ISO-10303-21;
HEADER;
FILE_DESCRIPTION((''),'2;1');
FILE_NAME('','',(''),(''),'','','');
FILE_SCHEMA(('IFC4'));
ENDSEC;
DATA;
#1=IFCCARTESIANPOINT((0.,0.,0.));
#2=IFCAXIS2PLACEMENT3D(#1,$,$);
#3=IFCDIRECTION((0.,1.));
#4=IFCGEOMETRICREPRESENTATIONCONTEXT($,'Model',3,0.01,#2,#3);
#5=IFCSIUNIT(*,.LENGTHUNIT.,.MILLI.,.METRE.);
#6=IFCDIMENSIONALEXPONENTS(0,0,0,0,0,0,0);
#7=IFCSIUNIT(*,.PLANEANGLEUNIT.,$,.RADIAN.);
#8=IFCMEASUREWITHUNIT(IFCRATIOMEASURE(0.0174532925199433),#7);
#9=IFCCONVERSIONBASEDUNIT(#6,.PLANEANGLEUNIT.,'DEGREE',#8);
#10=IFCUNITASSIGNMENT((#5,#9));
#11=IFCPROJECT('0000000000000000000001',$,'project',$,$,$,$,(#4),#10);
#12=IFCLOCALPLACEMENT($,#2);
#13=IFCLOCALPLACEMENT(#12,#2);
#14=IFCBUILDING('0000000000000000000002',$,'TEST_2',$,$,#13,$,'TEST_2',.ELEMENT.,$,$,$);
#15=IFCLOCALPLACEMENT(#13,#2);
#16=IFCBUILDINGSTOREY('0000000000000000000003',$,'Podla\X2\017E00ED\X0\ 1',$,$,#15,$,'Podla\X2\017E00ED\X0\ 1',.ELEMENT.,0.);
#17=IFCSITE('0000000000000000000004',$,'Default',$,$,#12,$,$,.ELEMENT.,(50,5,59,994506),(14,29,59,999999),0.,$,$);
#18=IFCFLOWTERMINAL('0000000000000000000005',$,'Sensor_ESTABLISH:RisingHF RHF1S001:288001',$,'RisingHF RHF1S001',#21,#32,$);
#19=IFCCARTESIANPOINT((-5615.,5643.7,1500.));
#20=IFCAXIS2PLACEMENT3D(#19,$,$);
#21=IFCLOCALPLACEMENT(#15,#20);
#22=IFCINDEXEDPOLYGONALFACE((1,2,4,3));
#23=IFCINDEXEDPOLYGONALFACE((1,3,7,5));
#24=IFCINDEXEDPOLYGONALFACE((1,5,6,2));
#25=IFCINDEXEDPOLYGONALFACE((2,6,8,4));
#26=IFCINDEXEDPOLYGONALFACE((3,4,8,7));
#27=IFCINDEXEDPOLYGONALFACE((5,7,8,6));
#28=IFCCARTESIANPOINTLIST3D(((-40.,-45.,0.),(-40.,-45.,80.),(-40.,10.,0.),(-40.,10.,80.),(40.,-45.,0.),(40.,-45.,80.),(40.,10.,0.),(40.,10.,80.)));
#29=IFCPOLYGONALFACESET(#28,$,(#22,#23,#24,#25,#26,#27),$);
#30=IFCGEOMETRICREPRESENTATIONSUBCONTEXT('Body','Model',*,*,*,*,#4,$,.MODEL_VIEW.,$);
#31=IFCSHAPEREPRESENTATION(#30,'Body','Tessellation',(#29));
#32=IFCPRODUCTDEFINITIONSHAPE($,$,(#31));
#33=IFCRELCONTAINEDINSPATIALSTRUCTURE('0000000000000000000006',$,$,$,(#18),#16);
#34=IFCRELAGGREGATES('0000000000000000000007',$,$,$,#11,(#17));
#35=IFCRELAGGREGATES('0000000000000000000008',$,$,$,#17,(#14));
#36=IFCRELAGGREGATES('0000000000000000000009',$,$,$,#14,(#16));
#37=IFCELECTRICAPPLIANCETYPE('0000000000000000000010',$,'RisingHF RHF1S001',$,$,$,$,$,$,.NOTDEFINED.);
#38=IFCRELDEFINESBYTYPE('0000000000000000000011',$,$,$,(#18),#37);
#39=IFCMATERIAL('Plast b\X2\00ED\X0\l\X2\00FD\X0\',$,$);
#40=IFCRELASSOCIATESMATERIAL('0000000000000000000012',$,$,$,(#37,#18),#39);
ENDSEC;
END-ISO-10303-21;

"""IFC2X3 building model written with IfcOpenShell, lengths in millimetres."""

from ifc_helpers import new_model, entity, si_unit, converted_unit, direction, frame, frame_2d, origin, place, context, subcontext, project, spatial, rectangle, extrude, source, transform, mapped, material, type_object, type_shapes, element, save


model = new_model("IFC2X3")

# Units and contexts
model_context = context("Model", 3, precision=0.01, world=origin(), true_north=direction((0.0, 1.0)))
body_context = subcontext(model_context, "Body", "Model", "MODEL_VIEW")
ifc_project = project(units=[si_unit("LENGTHUNIT", "METRE", prefix="MILLI"), converted_unit("PLANEANGLEUNIT", "DEGREE", entity("IfcRatioMeasure", 0.0174532925199433), si_unit("PLANEANGLEUNIT", "RADIAN"), dimensions=[0, 0, 0, 0, 0, 0, 0])], contexts=[model_context])

# Site, building, storey
site_placement = place(None, origin())
site = spatial("IfcSite", under=ifc_project, at=site_placement, Name="Default", CompositionType="ELEMENT", RefLatitude=(50, 5, 59, 994506), RefLongitude=(14, 29, 59, 999999), RefElevation=0.0)
building_placement = place(site_placement, origin())
building = spatial("IfcBuilding", under=site, at=building_placement, Name="TEST_2", LongName="TEST_2", CompositionType="ELEMENT")
storey_placement = place(building_placement, origin())
storey = spatial("IfcBuildingStorey", under=building, at=storey_placement, Name="Podlaží 1", LongName="Podlaží 1", CompositionType="ELEMENT", Elevation=0.0)

# Flow terminal
ifc_material_1 = material(Name="Plast bílý")
electric_appliance_type = type_object("IfcElectricApplianceType", Name="RisingHF RHF1S001", PredefinedType="NOTDEFINED", material=ifc_material_1)
shared_shape_1 = source(origin(), body_context, "Body", "SweptSolid", [
    extrude(rectangle(XDim=80.0, YDim=55.0, at=frame_2d((0.0, 0.0), x_axis=(1.0, 0.0))), frame((0.0, -17.5, 0.0), z_axis=(0.0, 0.0, 1.0), x_axis=(-1.0, 0.0, 0.0)), (0.0, 0.0, 1.0), 80.0),
])
type_shapes(electric_appliance_type, [shared_shape_1])
flow_terminal_placement = place(storey_placement, frame((-5615.0, 5643.7, 1500.0)))
element("IfcFlowTerminal", 1, at=flow_terminal_placement, inside=storey, type_object=electric_appliance_type, material=ifc_material_1, Name="Sensor_ESTABLISH:RisingHF RHF1S001:288001", ObjectType="RisingHF RHF1S001", context=body_context, shape_type="MappedRepresentation", body=[
    mapped(shared_shape_1, transform((0.0, 0.0, 0.0), scale=1.0)),
])

save(model, "model.ifc")
